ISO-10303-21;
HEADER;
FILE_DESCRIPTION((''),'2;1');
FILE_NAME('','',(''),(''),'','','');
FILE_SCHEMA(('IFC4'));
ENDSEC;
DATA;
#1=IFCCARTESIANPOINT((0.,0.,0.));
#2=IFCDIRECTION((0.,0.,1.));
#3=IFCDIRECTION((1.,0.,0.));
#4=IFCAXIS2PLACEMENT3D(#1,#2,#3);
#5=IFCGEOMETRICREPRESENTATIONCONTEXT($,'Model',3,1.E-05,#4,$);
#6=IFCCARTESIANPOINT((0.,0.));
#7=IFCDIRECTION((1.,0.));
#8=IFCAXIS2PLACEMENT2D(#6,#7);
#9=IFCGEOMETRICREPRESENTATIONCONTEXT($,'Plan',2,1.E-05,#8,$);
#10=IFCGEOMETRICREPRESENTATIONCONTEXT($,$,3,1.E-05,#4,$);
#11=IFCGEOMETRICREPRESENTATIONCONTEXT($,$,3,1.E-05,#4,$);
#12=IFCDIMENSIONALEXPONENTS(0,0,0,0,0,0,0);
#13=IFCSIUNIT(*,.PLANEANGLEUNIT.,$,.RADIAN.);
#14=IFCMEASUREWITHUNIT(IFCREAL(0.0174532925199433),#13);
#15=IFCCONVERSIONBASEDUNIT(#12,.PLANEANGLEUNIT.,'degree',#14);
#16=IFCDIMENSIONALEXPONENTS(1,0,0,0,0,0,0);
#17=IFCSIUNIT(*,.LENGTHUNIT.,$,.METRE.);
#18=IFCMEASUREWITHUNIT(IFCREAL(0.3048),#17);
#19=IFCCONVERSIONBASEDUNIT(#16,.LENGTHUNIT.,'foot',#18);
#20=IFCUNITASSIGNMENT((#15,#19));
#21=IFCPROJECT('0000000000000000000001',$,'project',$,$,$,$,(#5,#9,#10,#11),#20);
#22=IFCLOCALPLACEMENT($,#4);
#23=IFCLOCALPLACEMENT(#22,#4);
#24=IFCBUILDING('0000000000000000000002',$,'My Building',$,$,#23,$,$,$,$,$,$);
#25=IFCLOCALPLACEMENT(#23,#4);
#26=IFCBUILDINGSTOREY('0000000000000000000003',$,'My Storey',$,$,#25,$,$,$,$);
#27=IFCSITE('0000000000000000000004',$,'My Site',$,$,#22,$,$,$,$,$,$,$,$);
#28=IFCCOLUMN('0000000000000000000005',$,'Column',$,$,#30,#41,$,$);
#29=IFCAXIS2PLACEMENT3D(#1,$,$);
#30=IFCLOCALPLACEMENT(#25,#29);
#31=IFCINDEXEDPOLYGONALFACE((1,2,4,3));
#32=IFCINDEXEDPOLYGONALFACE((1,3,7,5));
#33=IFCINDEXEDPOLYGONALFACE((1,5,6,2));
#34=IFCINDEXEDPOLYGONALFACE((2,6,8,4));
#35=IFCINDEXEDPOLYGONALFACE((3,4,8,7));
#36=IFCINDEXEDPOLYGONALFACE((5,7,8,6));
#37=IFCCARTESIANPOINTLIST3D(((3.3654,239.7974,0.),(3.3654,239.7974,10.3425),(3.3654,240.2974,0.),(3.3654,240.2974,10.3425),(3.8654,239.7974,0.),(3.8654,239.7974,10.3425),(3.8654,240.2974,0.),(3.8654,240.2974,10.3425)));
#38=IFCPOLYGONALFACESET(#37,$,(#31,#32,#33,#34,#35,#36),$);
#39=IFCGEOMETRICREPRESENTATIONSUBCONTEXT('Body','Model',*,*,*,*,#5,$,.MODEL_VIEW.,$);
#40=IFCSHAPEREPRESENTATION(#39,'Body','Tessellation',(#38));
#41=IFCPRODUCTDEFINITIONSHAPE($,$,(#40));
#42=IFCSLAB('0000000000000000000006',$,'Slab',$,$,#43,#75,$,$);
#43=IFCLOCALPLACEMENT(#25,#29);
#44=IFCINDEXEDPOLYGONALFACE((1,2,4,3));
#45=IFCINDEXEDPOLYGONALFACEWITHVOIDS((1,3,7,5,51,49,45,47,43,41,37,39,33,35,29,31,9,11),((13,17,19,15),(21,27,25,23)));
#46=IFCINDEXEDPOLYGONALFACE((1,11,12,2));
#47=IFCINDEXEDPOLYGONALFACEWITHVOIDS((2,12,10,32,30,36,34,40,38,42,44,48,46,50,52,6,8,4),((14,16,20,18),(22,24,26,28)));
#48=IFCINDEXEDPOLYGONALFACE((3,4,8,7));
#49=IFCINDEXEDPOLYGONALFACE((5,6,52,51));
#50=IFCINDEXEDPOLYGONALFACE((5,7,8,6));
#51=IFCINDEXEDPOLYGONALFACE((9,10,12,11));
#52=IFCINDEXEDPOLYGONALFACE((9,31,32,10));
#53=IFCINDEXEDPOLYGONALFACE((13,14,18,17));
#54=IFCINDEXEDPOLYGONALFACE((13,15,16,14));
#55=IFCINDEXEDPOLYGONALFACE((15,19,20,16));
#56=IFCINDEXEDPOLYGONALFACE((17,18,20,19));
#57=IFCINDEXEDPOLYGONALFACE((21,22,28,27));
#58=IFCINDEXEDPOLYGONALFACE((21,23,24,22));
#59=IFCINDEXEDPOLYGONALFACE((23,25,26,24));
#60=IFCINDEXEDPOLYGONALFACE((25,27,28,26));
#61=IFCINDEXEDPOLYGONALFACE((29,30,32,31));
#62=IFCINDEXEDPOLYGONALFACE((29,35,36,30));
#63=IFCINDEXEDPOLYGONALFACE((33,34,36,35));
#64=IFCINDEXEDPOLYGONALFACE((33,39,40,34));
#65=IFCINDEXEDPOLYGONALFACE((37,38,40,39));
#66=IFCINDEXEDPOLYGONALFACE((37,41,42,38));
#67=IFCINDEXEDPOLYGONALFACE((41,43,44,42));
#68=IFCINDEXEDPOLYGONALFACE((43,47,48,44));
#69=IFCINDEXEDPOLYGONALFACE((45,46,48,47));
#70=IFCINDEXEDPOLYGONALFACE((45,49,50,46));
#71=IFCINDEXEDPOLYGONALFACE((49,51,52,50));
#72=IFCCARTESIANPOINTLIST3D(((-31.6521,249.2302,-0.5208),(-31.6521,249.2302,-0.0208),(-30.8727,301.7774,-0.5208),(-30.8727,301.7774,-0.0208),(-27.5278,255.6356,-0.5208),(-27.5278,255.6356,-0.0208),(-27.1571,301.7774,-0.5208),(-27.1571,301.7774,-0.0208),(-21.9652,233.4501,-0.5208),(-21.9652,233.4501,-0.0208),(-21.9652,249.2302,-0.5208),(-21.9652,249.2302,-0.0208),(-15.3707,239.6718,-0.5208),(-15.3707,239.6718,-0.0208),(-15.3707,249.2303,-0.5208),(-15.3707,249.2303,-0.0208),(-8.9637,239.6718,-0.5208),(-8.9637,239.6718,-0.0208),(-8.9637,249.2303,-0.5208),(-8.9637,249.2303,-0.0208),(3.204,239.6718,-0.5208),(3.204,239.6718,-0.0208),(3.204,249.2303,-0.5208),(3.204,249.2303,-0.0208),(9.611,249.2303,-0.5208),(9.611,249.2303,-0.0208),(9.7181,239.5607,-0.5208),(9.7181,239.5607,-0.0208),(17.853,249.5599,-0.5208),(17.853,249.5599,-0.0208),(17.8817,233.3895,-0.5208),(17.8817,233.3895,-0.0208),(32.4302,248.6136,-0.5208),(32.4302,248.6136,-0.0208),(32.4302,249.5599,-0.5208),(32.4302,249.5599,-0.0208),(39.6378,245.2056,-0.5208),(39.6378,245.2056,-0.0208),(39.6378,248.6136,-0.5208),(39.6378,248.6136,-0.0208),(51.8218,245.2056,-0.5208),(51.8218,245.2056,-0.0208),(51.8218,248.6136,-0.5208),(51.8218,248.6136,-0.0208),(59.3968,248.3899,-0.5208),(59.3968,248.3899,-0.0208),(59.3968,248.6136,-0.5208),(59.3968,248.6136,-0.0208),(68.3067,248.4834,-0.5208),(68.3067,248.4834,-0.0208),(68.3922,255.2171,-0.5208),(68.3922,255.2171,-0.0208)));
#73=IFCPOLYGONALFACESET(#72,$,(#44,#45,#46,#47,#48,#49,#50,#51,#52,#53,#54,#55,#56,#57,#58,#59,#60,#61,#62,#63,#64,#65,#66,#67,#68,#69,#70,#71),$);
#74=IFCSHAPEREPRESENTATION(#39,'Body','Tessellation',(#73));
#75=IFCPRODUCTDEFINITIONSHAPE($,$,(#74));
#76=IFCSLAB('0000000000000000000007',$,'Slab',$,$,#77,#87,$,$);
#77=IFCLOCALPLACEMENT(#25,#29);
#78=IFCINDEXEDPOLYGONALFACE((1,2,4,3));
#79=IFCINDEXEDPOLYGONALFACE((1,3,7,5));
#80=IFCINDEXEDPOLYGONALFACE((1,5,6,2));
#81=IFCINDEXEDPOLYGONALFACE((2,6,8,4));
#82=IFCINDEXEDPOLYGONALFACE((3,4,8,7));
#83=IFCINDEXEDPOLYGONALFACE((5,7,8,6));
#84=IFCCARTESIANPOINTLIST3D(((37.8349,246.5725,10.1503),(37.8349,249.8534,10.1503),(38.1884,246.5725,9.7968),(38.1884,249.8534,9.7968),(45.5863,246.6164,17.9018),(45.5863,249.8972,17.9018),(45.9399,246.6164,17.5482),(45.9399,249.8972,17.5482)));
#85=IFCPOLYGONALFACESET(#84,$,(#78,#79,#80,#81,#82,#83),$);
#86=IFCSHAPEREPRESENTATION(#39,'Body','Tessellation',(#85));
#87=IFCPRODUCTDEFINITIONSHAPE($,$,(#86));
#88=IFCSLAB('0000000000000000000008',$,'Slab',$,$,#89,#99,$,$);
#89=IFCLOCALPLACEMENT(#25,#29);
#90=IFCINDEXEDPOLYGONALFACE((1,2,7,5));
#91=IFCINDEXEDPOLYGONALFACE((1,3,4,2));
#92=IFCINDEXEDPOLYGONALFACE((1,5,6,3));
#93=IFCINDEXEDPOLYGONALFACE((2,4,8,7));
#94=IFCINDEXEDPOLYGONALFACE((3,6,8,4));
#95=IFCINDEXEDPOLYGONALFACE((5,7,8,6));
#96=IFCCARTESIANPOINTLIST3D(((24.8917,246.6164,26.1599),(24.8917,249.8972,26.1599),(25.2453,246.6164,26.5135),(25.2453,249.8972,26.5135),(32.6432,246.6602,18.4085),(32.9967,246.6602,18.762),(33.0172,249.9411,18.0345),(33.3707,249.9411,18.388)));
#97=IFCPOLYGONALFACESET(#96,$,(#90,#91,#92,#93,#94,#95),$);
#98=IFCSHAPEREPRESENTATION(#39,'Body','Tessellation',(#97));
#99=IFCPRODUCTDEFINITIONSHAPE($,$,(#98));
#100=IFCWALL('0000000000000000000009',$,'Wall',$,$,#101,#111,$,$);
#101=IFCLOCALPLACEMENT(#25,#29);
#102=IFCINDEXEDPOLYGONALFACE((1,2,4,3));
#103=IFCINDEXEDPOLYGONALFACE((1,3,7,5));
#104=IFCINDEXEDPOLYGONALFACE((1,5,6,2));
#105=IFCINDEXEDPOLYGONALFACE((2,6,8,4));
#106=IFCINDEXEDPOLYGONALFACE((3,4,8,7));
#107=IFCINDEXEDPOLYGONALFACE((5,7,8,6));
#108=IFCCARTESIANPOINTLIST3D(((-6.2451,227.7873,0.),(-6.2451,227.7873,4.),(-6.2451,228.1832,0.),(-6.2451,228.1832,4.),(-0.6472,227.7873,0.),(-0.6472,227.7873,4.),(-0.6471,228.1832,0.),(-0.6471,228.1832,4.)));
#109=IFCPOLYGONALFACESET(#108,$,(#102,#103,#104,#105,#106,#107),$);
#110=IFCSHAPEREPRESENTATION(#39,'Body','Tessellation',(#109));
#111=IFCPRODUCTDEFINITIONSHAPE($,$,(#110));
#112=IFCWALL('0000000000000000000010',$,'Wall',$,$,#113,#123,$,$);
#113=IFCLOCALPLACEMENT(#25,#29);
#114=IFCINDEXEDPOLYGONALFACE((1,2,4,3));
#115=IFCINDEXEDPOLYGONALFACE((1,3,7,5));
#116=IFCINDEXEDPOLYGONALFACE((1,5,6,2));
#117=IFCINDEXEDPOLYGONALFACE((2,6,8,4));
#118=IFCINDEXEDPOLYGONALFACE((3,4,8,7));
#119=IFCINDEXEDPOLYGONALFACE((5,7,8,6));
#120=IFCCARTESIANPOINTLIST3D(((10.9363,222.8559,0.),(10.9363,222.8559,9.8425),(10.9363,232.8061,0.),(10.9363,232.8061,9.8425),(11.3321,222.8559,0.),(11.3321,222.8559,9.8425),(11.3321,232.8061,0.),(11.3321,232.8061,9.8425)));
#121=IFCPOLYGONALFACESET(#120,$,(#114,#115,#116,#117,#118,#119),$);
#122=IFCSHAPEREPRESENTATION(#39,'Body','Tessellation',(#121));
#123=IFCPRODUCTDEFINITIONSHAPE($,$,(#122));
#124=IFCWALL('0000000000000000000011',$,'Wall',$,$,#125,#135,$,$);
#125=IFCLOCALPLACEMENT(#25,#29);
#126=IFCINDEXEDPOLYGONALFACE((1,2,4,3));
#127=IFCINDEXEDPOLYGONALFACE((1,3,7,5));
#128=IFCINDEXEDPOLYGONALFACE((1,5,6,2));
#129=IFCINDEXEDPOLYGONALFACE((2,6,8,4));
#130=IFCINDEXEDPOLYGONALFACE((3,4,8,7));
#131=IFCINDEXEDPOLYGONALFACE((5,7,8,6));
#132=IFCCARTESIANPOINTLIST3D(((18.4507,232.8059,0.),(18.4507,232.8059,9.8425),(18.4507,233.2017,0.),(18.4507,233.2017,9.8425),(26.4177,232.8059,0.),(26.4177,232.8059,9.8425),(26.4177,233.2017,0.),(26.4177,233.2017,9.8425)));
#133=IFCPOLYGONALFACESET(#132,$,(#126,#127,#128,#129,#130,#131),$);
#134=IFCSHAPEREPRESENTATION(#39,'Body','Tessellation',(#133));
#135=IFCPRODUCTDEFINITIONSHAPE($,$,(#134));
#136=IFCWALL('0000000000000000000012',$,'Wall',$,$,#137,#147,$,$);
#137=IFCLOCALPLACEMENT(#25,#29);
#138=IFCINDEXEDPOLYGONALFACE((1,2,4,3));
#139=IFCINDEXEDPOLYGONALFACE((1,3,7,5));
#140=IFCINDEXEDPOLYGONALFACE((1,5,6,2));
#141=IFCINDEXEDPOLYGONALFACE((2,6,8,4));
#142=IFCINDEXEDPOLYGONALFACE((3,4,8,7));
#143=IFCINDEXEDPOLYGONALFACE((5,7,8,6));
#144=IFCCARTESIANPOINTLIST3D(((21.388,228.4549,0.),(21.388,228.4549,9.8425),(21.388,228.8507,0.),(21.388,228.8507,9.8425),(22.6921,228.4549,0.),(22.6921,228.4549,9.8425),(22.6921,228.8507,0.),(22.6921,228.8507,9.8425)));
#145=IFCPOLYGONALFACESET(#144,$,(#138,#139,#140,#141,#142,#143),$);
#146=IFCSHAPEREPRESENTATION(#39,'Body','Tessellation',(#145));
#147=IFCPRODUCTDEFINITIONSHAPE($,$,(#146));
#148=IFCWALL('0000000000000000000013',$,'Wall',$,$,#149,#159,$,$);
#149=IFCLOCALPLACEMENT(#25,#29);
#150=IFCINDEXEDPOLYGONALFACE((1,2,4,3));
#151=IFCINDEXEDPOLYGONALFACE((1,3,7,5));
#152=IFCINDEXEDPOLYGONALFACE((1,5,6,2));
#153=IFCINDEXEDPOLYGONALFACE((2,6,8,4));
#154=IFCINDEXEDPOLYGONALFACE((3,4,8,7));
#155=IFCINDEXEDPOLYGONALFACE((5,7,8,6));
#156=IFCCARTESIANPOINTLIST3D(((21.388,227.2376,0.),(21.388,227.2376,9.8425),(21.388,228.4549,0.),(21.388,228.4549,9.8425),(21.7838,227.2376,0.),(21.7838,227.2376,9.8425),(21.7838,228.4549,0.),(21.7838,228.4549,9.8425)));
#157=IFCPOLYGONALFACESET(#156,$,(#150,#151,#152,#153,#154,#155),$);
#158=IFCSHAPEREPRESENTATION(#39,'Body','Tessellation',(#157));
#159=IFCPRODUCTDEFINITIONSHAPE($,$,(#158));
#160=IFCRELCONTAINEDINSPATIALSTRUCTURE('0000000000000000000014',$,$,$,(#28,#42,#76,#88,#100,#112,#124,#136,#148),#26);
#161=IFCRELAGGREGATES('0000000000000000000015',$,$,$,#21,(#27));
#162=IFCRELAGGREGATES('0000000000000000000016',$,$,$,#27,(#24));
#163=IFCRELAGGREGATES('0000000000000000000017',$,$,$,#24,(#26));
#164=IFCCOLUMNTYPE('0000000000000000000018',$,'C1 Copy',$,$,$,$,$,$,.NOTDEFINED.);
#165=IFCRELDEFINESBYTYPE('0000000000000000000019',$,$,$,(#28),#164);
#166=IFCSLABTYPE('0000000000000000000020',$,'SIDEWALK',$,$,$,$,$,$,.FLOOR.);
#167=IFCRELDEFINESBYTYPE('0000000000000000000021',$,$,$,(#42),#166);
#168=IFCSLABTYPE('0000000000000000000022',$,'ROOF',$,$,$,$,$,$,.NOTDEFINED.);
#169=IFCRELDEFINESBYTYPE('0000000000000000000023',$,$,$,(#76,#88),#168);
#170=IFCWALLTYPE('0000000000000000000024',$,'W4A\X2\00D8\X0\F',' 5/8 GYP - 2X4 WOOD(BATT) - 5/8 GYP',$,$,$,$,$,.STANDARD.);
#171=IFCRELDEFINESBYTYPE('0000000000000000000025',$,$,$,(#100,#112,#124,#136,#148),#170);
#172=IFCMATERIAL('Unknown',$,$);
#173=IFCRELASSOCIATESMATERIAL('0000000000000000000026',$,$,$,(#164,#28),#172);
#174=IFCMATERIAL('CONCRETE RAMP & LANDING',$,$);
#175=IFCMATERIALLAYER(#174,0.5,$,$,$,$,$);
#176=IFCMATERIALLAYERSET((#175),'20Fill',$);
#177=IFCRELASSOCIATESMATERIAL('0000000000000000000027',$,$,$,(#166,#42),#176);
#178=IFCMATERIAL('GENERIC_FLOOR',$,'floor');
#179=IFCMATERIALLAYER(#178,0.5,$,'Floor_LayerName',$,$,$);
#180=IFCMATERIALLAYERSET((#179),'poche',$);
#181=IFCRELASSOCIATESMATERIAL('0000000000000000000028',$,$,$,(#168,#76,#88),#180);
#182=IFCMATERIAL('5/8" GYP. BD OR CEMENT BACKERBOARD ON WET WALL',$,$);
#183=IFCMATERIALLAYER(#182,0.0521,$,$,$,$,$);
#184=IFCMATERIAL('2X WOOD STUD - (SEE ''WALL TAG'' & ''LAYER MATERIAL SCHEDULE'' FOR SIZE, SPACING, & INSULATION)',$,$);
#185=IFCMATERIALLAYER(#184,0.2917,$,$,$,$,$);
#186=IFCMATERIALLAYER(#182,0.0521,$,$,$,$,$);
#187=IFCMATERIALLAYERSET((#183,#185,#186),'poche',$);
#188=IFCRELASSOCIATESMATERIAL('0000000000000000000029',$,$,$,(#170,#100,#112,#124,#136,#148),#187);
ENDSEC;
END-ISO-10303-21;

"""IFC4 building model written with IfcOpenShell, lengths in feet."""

from ifc_helpers import new_model, entity, si_unit, converted_unit, frame, origin_with_axes, origin_2d_with_axis, place, context, subcontext, project, spatial, line, indexed_curve, rectangle, outline, extrude, material, layer, layer_set, layer_usage, material_profile, profile_set, profile_usage, type_object, element, save


model = new_model("IFC4")

# Units and contexts
model_context = context("Model", 3, precision=1e-05, world=origin_with_axes())
plan_context = context("Plan", 2, precision=1e-05, world=origin_2d_with_axis())
context_of_model_1 = context(None, 3, precision=1e-05, world=origin_with_axes())
context_of_model_2 = context(None, 3, precision=1e-05, world=origin_with_axes())
body_context = subcontext(model_context, "Body", "Model", "MODEL_VIEW")
ifc_project = project(units=[converted_unit("PLANEANGLEUNIT", "degree", entity("IfcReal", 0.0174532925199433), si_unit("PLANEANGLEUNIT", "RADIAN"), dimensions=[0, 0, 0, 0, 0, 0, 0]), converted_unit("LENGTHUNIT", "foot", entity("IfcReal", 0.3048), si_unit("LENGTHUNIT", "METRE"), dimensions=[1, 0, 0, 0, 0, 0, 0])], contexts=[model_context, plan_context, context_of_model_1, context_of_model_2])

# Site, building, storey
site_placement = place(None, origin_with_axes())
site = spatial("IfcSite", under=ifc_project, at=site_placement, Name="My Site")
building_placement = place(site_placement, origin_with_axes())
building = spatial("IfcBuilding", under=site, at=building_placement, Name="My Building")
storey_placement = place(building_placement, origin_with_axes())
storey = spatial("IfcBuildingStorey", under=building, at=storey_placement, Name="My Storey")

# Column
ifc_material_1 = material(Name="Unknown")
ifc_material_profile = material_profile(ifc_material_1, rectangle(XDim=0.5, YDim=0.5))
ifc_profile_set = profile_set([ifc_material_profile])
ifc_profile_usage = profile_usage(ifc_profile_set, cardinal=5)
column_type = type_object("IfcColumnType", Name="C1 Copy", PredefinedType="NOTDEFINED", material=ifc_profile_set)
column_placement = place(storey_placement, frame((3.6154, 240.0474, 0.0), z_axis=(0.0, 0.0, 1.0), x_axis=(1.0, 0.0, 0.0)))
element("IfcColumn", 1, at=column_placement, inside=storey, type_object=column_type, material=ifc_profile_usage, Name="Column", context=body_context, shape_type="SweptSolid", body=[
    extrude(rectangle(XDim=0.5, YDim=0.5), origin_with_axes(), (0.0, 0.0, 1.0), 10.3425),
])

# Slabs
ifc_material_2 = material(Name="CONCRETE RAMP & LANDING")
ifc_layer_1 = layer(ifc_material_2, 0.5)
ifc_layer_set_1 = layer_set([ifc_layer_1], Name="20Fill")
ifc_layer_usage_1 = layer_usage(ifc_layer_set_1, "AXIS3", "POSITIVE", 0.0)
slab_type_1 = type_object("IfcSlabType", Name="SIDEWALK", PredefinedType="FLOOR", material=ifc_layer_set_1)
slab_1_placement = place(storey_placement, frame((3.204, 249.2303, -0.5208), z_axis=(0.0, 0.0, 1.0), x_axis=(1.0, 0.0, 0.0)))
element("IfcSlab", 2, at=slab_1_placement, inside=storey, type_object=slab_type_1, material=ifc_layer_usage_1, Name="Slab", context=body_context, shape_type="SweptSolid", body=[
    extrude(outline(indexed_curve([(-30.3611, 52.5471), (-34.0767, 52.5471), (-34.856, 0.0), (-25.1691, 0.0), (-25.1691, -15.7802), (14.6777, -15.8408), (14.6491, 0.3296), (36.4338, -0.6167), (36.4338, -4.0246), (48.6178, -4.0246), (48.6178, -0.6167), (56.1929, -0.6167), (56.1929, -0.8404), (65.1027, -0.7468), (65.1882, 5.9868), (-30.7318, 6.4054), (-18.5747, 0.0), (-18.5747, -9.5584), (-12.1677, -9.5584), (-12.1677, 0.0), (6.5141, -9.6695), (6.407, 0.0), (0.0, 0.0), (0.0, -9.5584), (29.2262, 0.3296), (29.2262, -0.6167)], segments=[line(4, 3), line(3, 2), line(2, 1), line(1, 16), line(16, 15), line(15, 14), line(14, 13), line(13, 12), line(12, 11), line(11, 10), line(10, 9), line(9, 8), line(8, 26), line(26, 25), line(25, 7), line(7, 6), line(6, 5), line(5, 4)], self_intersect=False), holes=[indexed_curve([(-30.3611, 52.5471), (-34.0767, 52.5471), (-34.856, 0.0), (-25.1691, 0.0), (-25.1691, -15.7802), (14.6777, -15.8408), (14.6491, 0.3296), (36.4338, -0.6167), (36.4338, -4.0246), (48.6178, -4.0246), (48.6178, -0.6167), (56.1929, -0.6167), (56.1929, -0.8404), (65.1027, -0.7468), (65.1882, 5.9868), (-30.7318, 6.4054), (-18.5747, 0.0), (-18.5747, -9.5584), (-12.1677, -9.5584), (-12.1677, 0.0), (6.5141, -9.6695), (6.407, 0.0), (0.0, 0.0), (0.0, -9.5584), (29.2262, 0.3296), (29.2262, -0.6167)], segments=[line(24, 23), line(23, 22), line(22, 21), line(21, 24)], self_intersect=False), indexed_curve([(-30.3611, 52.5471), (-34.0767, 52.5471), (-34.856, 0.0), (-25.1691, 0.0), (-25.1691, -15.7802), (14.6777, -15.8408), (14.6491, 0.3296), (36.4338, -0.6167), (36.4338, -4.0246), (48.6178, -4.0246), (48.6178, -0.6167), (56.1929, -0.6167), (56.1929, -0.8404), (65.1027, -0.7468), (65.1882, 5.9868), (-30.7318, 6.4054), (-18.5747, 0.0), (-18.5747, -9.5584), (-12.1677, -9.5584), (-12.1677, 0.0), (6.5141, -9.6695), (6.407, 0.0), (0.0, 0.0), (0.0, -9.5584), (29.2262, 0.3296), (29.2262, -0.6167)], segments=[line(18, 19), line(19, 20), line(20, 17), line(17, 18)], self_intersect=False)]), None, (0.0, 0.0, 1.0), 0.5),
])
ifc_material_3 = material(Name="GENERIC_FLOOR", Category="floor")
ifc_layer_2 = layer(ifc_material_3, 0.5, Name="Floor_LayerName")
ifc_layer_set_2 = layer_set([ifc_layer_2], Name="poche")
ifc_layer_usage_2 = layer_usage(ifc_layer_set_2, "AXIS3", "POSITIVE", 0.0)
slab_type_2 = type_object("IfcSlabType", Name="ROOF", PredefinedType="NOTDEFINED", material=ifc_layer_set_2)
slab_2_placement = place(storey_placement, frame((38.1884, 249.8534, 9.7968), z_axis=(-0.707107, 0.0, 0.707107), x_axis=(0.0, -1.0, 0.0)))
element("IfcSlab", 3, at=slab_2_placement, inside=storey, type_object=slab_type_2, material=ifc_layer_usage_2, Name="Slab", context=body_context, shape_type="SweptSolid", body=[
    extrude(outline(indexed_curve([(0.0, 0.0), (-0.0438, 10.9622), (3.237, 10.9622), (3.2808, 0.0)], segments=[line(3, 2), line(2, 1), line(1, 4), line(4, 3)], self_intersect=False)), None, (0.0, 0.0, 1.0), 0.5),
])
ifc_layer_usage_3 = layer_usage(ifc_layer_set_2, "AXIS3", "POSITIVE", 0.0)
slab_3_placement = place(storey_placement, frame((32.6432, 246.6602, 18.4085), z_axis=(0.707107, 0.000001, 0.707107), x_axis=(-0.000001, 1.0, 0.0)))
element("IfcSlab", 4, at=slab_3_placement, inside=storey, type_object=slab_type_2, material=ifc_layer_usage_3, Name="Slab", context=body_context, shape_type="SweptSolid", body=[
    extrude(outline(indexed_curve([(3.237, 10.9622), (-0.0438, 10.9622), (0.0, 0.0), (3.2808, -0.5289)], segments=[line(3, 2), line(2, 1), line(1, 4), line(4, 3)], self_intersect=False)), None, (0.0, 0.0, 1.0), 0.5),
])

# Walls
ifc_material_4 = material(Name="5/8\" GYP. BD OR CEMENT BACKERBOARD ON WET WALL")
ifc_layer_3 = layer(ifc_material_4, 0.0521)
ifc_material_5 = material(Name="2X WOOD STUD - (SEE 'WALL TAG' & 'LAYER MATERIAL SCHEDULE' FOR SIZE, SPACING, & INSULATION)")
ifc_layer_4 = layer(ifc_material_5, 0.2917)
ifc_layer_5 = layer(ifc_material_4, 0.0521)
ifc_layer_set_3 = layer_set([ifc_layer_3, ifc_layer_4, ifc_layer_5], Name="poche")
ifc_layer_usage_4 = layer_usage(ifc_layer_set_3, "AXIS2", "POSITIVE", 0.0)
wall_type_1 = type_object("IfcWallType", Name="W4AØF", Description=" 5/8 GYP - 2X4 WOOD(BATT) - 5/8 GYP", PredefinedType="STANDARD", material=ifc_layer_set_3)
wall_1_placement = place(storey_placement, frame((-0.6471, 228.1832, 0.0), z_axis=(0.0, 0.0, 1.0), x_axis=(-1.0, 0.0, 0.0)))
element("IfcWall", 5, at=wall_1_placement, inside=storey, type_object=wall_type_1, material=ifc_layer_usage_4, Name="Wall", context=body_context, shape_type="SweptSolid", body=[
    extrude(outline(indexed_curve([(0.0, 0.0), (0.0, 0.3958), (5.5979, 0.3958), (5.5979, 0.0), (0.0, 0.0)], self_intersect=False)), origin_with_axes(), (0.0, 0.0, 1.0), 4.0),
])
ifc_layer_usage_5 = layer_usage(ifc_layer_set_3, "AXIS2", "POSITIVE", 0.0)
wall_2_placement = place(storey_placement, frame((10.9363, 232.8061, 0.0), z_axis=(0.0, 0.0, 1.0), x_axis=(-0.000001, -1.0, 0.0)))
element("IfcWall", 6, at=wall_2_placement, inside=storey, type_object=wall_type_1, material=ifc_layer_usage_5, Name="Wall", context=body_context, shape_type="SweptSolid", body=[
    extrude(outline(indexed_curve([(0.0, 0.0), (0.0, 0.3958), (9.9502, 0.3958), (9.9502, 0.0), (0.0, 0.0)], self_intersect=False)), origin_with_axes(), (0.0, 0.0, 1.0), 9.8425),
])

# Walls
ifc_layer_usage_6 = layer_usage(ifc_layer_set_3, "AXIS2", "POSITIVE", 0.0)
wall_3_placement = place(storey_placement, frame((18.4507, 232.8059, 0.0), z_axis=(0.0, 0.0, 1.0), x_axis=(1.0, 0.0, 0.0)))
element("IfcWall", 7, at=wall_3_placement, inside=storey, type_object=wall_type_1, material=ifc_layer_usage_6, Name="Wall", context=body_context, shape_type="SweptSolid", body=[
    extrude(outline(indexed_curve([(0.0, 0.0), (0.0, 0.3958), (7.967, 0.3958), (7.967, 0.0), (0.0, 0.0)], self_intersect=False)), origin_with_axes(), (0.0, 0.0, 1.0), 9.8425),
])
ifc_layer_usage_7 = layer_usage(ifc_layer_set_3, "AXIS2", "POSITIVE", 0.0)
wall_4_placement = place(storey_placement, frame((22.6921, 228.8507, 0.0), z_axis=(0.0, 0.0, 1.0), x_axis=(-1.0, 0.0, 0.0)))
element("IfcWall", 8, at=wall_4_placement, inside=storey, type_object=wall_type_1, material=ifc_layer_usage_7, Name="Wall", context=body_context, shape_type="SweptSolid", body=[
    extrude(outline(indexed_curve([(0.0, 0.0), (0.0, 0.3958), (1.3042, 0.3958), (1.3042, 0.0), (0.0, 0.0)], self_intersect=False)), origin_with_axes(), (0.0, 0.0, 1.0), 9.8425),
])
ifc_layer_usage_8 = layer_usage(ifc_layer_set_3, "AXIS2", "POSITIVE", 0.0)
wall_5_placement = place(storey_placement, frame((21.388, 228.4549, 0.0), z_axis=(0.0, 0.0, 1.0), x_axis=(0.0, -1.0, 0.0)))
element("IfcWall", 9, at=wall_5_placement, inside=storey, type_object=wall_type_1, material=ifc_layer_usage_8, Name="Wall", context=body_context, shape_type="SweptSolid", body=[
    extrude(outline(indexed_curve([(0.0, 0.0), (0.0, 0.3958), (1.2172, 0.3958), (1.2172, 0.0), (0.0, 0.0)], self_intersect=False)), origin_with_axes(), (0.0, 0.0, 1.0), 9.8425),
])

save(model, "model.ifc")
